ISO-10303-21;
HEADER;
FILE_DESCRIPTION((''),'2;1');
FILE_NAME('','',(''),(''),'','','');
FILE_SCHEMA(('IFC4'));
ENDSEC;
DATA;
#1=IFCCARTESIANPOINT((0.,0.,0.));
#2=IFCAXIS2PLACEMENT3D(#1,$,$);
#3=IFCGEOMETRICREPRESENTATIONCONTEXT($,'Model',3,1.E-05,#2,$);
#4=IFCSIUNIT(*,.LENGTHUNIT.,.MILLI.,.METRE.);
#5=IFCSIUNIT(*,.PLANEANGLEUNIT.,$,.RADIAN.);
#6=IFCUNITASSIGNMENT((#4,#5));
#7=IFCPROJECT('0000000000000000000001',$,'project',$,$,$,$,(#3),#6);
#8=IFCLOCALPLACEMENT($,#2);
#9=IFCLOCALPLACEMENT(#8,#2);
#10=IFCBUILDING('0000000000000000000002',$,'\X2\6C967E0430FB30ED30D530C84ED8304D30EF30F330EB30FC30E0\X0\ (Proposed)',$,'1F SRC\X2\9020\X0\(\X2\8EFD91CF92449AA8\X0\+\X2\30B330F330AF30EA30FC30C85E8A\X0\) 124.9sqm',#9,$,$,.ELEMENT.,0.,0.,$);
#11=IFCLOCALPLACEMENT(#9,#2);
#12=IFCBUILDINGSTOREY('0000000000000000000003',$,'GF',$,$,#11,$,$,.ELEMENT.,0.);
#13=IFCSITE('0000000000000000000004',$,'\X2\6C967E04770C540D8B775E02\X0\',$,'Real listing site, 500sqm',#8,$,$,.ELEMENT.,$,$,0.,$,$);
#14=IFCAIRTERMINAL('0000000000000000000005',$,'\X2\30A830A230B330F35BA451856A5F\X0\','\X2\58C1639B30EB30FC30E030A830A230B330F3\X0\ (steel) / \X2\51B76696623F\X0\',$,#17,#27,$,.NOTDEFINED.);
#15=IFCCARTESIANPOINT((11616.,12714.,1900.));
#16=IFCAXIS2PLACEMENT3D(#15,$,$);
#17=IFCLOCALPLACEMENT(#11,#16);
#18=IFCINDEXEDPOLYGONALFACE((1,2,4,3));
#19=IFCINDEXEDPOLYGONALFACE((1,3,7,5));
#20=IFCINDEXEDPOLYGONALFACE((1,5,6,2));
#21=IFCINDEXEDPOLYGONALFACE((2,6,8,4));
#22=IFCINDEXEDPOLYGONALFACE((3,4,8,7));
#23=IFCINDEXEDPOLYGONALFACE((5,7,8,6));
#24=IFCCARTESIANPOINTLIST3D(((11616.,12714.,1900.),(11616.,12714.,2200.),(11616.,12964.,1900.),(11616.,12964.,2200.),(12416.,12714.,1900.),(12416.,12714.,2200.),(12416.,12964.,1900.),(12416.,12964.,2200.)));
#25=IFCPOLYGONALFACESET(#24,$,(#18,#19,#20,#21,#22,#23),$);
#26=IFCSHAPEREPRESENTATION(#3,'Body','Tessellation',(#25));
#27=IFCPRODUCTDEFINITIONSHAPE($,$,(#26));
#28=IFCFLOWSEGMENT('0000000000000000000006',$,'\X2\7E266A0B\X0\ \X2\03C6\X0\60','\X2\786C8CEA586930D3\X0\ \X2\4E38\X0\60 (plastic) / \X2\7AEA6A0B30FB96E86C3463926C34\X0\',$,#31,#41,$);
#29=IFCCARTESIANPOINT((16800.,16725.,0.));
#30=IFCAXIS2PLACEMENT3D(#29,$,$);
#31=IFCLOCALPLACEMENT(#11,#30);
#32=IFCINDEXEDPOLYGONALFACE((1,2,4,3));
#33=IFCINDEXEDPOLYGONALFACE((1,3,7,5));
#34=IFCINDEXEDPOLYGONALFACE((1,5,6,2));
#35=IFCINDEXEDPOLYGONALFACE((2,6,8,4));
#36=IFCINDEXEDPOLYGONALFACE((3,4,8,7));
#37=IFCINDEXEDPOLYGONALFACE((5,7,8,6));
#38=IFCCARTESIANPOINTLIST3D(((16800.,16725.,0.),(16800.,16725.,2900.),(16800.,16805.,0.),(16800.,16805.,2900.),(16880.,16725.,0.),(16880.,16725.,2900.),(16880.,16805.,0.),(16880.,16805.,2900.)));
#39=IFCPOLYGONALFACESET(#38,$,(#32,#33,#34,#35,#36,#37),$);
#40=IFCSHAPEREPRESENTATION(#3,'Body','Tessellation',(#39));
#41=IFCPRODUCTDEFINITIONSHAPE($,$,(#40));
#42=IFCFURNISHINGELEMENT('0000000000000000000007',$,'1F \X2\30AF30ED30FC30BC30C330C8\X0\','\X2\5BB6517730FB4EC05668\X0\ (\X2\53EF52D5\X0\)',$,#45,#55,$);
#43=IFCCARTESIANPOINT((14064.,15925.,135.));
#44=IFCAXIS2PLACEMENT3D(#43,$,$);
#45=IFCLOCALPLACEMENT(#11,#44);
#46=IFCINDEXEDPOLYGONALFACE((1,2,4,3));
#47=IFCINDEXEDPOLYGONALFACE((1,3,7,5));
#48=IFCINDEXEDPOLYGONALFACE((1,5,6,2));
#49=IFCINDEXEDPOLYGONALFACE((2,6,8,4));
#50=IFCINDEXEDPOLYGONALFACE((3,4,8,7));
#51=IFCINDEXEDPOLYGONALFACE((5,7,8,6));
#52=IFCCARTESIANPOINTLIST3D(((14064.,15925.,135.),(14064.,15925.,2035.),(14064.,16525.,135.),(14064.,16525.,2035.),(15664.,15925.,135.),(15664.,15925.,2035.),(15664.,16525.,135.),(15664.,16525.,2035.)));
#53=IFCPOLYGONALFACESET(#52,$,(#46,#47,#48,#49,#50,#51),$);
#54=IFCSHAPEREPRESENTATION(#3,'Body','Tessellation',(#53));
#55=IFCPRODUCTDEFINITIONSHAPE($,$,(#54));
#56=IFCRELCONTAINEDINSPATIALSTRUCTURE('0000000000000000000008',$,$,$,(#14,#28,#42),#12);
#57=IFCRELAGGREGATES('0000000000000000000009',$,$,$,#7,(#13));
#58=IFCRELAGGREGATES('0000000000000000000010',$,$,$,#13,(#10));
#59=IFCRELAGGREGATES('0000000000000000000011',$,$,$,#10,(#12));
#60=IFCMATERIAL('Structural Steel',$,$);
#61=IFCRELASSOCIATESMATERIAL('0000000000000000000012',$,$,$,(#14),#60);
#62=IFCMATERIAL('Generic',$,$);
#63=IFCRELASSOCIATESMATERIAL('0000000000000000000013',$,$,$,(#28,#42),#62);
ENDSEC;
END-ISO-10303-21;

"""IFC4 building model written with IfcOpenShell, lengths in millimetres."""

from ifc_helpers import new_model, si_unit, frame, frame_2d, origin, place, context, project, spatial, rectangle, extrude, material, element, save


model = new_model("IFC4")

# Units and contexts
model_context = context("Model", 3, precision=1e-05, world=origin())
ifc_project = project(units=[si_unit("LENGTHUNIT", "METRE", prefix="MILLI"), si_unit("PLANEANGLEUNIT", "RADIAN")], contexts=[model_context])

# Site, building, storey
site_placement = place(None, origin())
site = spatial("IfcSite", under=ifc_project, at=site_placement, Name="沖縄県名護市", ObjectType="Real listing site, 500sqm", CompositionType="ELEMENT", RefElevation=0.0)
building_placement = place(site_placement, origin())
building = spatial("IfcBuilding", under=site, at=building_placement, Name="沖縄・ロフト付きワンルーム (Proposed)", ObjectType="1F SRC造(軽量鉄骨+コンクリート床) 124.9sqm", CompositionType="ELEMENT", ElevationOfRefHeight=0.0, ElevationOfTerrain=0.0)
storey_placement = place(building_placement, origin())
storey = spatial("IfcBuildingStorey", under=building, at=storey_placement, Name="GF", CompositionType="ELEMENT", Elevation=0.0)

# Shared definitions
ifc_material_1 = material(Name="Structural Steel")

# Shared definitions
ifc_material_2 = material(Name="Generic")

# Air terminal
air_terminal_placement = place(storey_placement, frame((11616.0, 12714.0, 1900.0)))
element("IfcAirTerminal", 1, at=air_terminal_placement, inside=storey, material=ifc_material_1, Name="エアコン室内機", Description="壁掛ルームエアコン (steel) / 冷暖房", PredefinedType="NOTDEFINED", context=model_context, shape_type="SweptSolid", body=[
    extrude(rectangle(XDim=800.0, YDim=250.0, at=frame_2d((400.0, 125.0))), frame((11616.0, 12714.0, 1900.0)), (0.0, 0.0, 1.0), 300.0),
])

# Flow segment
flow_segment_placement = place(storey_placement, frame((16800.0, 16725.0, 0.0)))
element("IfcFlowSegment", 2, at=flow_segment_placement, inside=storey, material=ifc_material_2, Name="縦樋 φ60", Description="硬質塩ビ 丸60 (plastic) / 竪樋・雨水排水", context=model_context, shape_type="SweptSolid", body=[
    extrude(rectangle(XDim=80.0, YDim=80.0, at=frame_2d((40.0, 40.0))), frame((16800.0, 16725.0, 0.0)), (0.0, 0.0, 1.0), 2900.0),
])

# Furnishing element
furnishing_placement = place(storey_placement, frame((14064.0, 15925.0, 135.0)))
element("IfcFurnishingElement", 3, at=furnishing_placement, inside=storey, material=ifc_material_2, Name="1F クローゼット", Description="家具・什器 (可動)", context=model_context, shape_type="SweptSolid", body=[
    extrude(rectangle(XDim=1600.0, YDim=600.0, at=frame_2d((800.0, 300.0))), frame((14064.0, 15925.0, 135.0)), (0.0, 0.0, 1.0), 1900.0),
])

save(model, "model.ifc")
